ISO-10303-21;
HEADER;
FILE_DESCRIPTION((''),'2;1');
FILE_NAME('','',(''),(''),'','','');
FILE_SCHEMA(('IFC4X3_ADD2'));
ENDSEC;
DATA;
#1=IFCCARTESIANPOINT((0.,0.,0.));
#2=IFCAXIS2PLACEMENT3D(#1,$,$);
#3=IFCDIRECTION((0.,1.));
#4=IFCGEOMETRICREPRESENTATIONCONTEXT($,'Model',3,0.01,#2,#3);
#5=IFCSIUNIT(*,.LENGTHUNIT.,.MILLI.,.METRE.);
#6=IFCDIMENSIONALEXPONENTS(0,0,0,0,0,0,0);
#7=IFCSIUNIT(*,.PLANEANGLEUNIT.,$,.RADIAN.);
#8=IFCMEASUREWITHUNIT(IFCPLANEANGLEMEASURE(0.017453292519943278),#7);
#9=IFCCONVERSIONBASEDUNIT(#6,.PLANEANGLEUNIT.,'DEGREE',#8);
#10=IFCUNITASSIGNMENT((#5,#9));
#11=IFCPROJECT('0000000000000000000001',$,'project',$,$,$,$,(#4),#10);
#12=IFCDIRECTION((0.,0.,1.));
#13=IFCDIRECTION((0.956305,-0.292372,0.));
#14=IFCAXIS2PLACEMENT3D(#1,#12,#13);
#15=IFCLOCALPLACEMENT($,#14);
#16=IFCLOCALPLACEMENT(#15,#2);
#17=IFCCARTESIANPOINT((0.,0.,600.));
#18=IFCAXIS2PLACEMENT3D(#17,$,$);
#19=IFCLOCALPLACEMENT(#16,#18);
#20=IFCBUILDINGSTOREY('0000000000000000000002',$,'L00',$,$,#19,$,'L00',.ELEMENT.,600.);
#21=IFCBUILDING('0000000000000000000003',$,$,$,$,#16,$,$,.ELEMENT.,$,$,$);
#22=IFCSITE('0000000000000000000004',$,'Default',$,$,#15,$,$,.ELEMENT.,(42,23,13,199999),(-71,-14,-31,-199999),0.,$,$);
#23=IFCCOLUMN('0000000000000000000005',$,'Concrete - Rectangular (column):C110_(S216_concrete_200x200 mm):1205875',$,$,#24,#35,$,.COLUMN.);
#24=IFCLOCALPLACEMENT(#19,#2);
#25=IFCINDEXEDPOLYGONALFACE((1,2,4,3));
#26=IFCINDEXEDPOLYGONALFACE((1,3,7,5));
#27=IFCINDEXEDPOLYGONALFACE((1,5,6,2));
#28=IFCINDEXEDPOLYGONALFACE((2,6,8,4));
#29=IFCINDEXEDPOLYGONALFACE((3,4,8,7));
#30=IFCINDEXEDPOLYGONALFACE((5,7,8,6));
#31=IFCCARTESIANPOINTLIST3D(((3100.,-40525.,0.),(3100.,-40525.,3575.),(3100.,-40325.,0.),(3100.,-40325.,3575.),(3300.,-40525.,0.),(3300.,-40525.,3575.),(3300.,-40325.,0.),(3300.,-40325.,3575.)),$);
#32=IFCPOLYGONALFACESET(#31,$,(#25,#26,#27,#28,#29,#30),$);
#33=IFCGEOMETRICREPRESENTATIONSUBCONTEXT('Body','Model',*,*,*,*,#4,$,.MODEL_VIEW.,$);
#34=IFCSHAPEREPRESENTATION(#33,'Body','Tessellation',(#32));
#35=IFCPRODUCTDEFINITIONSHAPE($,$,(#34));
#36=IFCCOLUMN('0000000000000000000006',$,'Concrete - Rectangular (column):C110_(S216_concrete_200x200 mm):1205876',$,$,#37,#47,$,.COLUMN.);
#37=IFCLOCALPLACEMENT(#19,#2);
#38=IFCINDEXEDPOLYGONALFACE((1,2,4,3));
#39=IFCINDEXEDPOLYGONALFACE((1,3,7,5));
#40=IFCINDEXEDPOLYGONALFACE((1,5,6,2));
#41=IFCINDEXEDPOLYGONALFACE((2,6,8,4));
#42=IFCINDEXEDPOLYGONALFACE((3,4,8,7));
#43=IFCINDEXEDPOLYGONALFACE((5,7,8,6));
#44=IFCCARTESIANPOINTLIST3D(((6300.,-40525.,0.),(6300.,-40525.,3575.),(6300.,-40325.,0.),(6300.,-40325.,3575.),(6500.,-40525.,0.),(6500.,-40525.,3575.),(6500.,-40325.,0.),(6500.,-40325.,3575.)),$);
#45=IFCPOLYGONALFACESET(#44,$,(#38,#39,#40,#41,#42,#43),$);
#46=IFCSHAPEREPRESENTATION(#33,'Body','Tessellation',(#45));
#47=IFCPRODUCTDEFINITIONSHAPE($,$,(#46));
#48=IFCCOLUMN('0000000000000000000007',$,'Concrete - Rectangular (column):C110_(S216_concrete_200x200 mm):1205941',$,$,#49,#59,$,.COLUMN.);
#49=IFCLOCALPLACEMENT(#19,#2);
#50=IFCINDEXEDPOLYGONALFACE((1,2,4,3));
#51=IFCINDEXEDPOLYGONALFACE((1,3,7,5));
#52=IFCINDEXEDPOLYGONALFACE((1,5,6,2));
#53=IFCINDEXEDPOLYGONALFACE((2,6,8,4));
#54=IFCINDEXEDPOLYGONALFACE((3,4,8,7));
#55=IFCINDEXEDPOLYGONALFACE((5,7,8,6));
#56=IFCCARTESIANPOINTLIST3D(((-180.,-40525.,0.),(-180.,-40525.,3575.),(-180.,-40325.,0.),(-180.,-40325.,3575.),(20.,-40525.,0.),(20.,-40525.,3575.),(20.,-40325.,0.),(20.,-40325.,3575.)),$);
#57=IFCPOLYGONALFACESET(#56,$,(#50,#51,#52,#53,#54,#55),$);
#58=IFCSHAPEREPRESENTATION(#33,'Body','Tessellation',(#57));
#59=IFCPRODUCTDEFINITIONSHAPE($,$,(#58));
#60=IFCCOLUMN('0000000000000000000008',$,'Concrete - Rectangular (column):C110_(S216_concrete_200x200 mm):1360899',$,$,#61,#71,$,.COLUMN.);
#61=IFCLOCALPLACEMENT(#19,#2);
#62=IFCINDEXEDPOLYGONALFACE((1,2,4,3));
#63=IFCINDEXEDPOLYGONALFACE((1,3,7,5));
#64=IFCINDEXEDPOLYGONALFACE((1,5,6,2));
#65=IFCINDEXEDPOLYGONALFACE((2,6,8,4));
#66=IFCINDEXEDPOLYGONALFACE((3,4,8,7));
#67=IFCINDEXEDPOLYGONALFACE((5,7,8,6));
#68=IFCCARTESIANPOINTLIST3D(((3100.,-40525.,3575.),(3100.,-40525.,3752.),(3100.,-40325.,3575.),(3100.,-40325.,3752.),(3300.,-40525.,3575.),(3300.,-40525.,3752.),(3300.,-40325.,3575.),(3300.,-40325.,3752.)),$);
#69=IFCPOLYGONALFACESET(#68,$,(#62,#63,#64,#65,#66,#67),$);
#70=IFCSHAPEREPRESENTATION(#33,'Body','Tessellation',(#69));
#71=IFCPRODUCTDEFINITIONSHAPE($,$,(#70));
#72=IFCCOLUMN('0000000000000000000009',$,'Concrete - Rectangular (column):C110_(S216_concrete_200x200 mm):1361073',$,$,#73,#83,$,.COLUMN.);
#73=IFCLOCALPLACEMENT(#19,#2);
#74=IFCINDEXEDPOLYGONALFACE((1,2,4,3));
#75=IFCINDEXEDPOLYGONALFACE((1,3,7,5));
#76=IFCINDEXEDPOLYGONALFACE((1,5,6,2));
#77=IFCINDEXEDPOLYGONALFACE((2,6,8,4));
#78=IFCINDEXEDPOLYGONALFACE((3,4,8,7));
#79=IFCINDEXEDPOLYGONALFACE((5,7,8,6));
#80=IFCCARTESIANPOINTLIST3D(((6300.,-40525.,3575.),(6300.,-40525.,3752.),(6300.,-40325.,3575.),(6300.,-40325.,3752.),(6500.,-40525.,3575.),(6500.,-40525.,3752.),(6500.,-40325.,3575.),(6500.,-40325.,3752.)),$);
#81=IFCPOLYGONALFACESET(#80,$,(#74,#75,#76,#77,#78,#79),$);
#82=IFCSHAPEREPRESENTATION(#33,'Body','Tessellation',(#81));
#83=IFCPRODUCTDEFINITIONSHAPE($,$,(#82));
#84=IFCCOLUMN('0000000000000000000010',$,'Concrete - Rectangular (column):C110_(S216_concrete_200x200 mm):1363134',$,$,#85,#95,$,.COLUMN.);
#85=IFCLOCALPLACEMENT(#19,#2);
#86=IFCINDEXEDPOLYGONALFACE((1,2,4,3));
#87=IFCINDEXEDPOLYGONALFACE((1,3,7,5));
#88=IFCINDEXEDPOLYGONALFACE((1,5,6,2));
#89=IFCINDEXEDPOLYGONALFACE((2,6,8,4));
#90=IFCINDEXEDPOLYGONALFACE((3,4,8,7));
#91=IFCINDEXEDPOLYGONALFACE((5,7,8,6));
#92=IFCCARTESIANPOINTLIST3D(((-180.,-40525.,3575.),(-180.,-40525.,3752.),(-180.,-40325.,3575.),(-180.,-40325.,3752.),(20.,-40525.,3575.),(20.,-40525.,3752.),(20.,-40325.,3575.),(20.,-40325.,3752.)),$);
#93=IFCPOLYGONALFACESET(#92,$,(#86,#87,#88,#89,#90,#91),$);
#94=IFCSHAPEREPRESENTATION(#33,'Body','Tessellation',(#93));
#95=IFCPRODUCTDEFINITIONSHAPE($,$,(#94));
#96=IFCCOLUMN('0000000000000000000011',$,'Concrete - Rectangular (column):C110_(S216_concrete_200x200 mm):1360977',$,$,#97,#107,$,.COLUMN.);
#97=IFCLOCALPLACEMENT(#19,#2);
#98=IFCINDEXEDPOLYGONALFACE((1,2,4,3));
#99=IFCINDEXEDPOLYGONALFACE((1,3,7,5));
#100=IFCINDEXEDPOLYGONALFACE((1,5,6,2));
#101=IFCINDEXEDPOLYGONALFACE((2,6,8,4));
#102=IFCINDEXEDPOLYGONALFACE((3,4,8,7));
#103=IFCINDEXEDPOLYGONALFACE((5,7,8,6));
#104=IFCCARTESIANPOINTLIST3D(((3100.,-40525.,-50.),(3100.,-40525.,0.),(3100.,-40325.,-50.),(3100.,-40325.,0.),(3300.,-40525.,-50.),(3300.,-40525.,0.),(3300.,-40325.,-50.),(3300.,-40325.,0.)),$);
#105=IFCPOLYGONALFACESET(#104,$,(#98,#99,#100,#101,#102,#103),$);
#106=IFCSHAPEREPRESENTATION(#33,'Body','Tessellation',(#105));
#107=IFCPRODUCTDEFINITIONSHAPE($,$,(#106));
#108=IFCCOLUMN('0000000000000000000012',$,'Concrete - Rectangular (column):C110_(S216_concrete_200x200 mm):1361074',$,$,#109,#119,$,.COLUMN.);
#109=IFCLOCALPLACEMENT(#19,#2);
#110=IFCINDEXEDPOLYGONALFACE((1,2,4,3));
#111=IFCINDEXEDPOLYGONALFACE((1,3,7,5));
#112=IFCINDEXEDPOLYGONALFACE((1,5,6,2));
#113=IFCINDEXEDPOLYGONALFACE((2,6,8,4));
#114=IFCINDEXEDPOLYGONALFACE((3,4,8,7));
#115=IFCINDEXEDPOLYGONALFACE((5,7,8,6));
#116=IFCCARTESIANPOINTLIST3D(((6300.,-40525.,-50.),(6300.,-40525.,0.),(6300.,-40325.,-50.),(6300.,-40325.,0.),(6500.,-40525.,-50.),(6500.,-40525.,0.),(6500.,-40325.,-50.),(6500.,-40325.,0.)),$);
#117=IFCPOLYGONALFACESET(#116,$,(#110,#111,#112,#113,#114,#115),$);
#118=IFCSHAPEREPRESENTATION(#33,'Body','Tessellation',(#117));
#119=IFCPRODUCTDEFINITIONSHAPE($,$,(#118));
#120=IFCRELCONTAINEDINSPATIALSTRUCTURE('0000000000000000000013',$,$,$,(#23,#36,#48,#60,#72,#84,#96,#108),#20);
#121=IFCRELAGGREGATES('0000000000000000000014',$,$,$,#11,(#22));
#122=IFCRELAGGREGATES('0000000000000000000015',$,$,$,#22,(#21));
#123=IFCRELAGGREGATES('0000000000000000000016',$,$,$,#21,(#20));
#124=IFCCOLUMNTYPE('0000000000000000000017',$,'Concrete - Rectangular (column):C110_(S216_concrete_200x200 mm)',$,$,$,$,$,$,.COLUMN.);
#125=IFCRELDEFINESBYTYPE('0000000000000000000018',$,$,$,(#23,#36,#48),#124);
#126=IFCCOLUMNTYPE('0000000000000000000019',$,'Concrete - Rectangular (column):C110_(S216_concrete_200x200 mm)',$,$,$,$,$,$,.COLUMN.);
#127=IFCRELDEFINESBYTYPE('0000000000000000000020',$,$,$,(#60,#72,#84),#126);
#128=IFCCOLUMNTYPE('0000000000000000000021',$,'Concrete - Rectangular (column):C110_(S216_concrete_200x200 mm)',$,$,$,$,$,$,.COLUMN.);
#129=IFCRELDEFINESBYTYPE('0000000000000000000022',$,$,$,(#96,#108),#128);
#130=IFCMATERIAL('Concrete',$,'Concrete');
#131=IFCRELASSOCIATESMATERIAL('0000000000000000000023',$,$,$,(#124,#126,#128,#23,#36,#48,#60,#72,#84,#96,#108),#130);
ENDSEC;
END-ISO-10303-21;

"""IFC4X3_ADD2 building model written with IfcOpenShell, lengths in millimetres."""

from ifc_helpers import new_model, entity, si_unit, converted_unit, direction, frame, origin, origin_2d_with_axis, place, context, subcontext, project, spatial, rectangle, extrude, source, transform, mapped, material, material_profile, profile_set, profile_usage, type_object, type_shapes, element, save


model = new_model("IFC4X3_ADD2")

# Units and contexts
model_context = context("Model", 3, precision=0.01, world=origin(), true_north=direction((0.0, 1.0)))
body_context = subcontext(model_context, "Body", "Model", "MODEL_VIEW")
ifc_project = project(units=[si_unit("LENGTHUNIT", "METRE", prefix="MILLI"), converted_unit("PLANEANGLEUNIT", "DEGREE", entity("IfcPlaneAngleMeasure", 0.017453292519943278), si_unit("PLANEANGLEUNIT", "RADIAN"), dimensions=[0, 0, 0, 0, 0, 0, 0])], contexts=[model_context])

# Site, building, storey
site_placement = place(None, frame((0.0, 0.0, 0.0), z_axis=(0.0, 0.0, 1.0), x_axis=(0.956305, -0.292372, 0.0)))
site = spatial("IfcSite", under=ifc_project, at=site_placement, Name="Default", CompositionType="ELEMENT", RefLatitude=(42, 23, 13, 199999), RefLongitude=(-71, -14, -31, -199999), RefElevation=0.0)
building_placement = place(site_placement, origin())
building = spatial("IfcBuilding", under=site, at=building_placement, CompositionType="ELEMENT")
storey_placement = place(building_placement, frame((0.0, 0.0, 600.0)))
storey = spatial("IfcBuildingStorey", under=building, at=storey_placement, Name="L00", LongName="L00", CompositionType="ELEMENT", Elevation=600.0)

# Columns
ifc_material_1 = material(Name="Concrete", Category="Concrete")
ifc_material_profile_1 = material_profile(ifc_material_1, rectangle(XDim=200.0, YDim=200.0, at=origin_2d_with_axis()), Name="C110_(S216_concrete_200x200 mm)")
ifc_profile_set_1 = profile_set([ifc_material_profile_1], Name="C110_(S216_concrete_200x200 mm)")
ifc_profile_usage_1 = profile_usage(ifc_profile_set_1)
column_type_1 = type_object("IfcColumnType", Name="Concrete - Rectangular (column):C110_(S216_concrete_200x200 mm)", PredefinedType="COLUMN", material=ifc_profile_set_1)
shared_shape_1 = source(origin(), body_context, "Body", "SweptSolid", [
    extrude(rectangle(XDim=200.0, YDim=200.0, at=origin_2d_with_axis()), frame((0.0, 0.0, 600.0), z_axis=(0.0, 0.0, 1.0), x_axis=(-1.0, 0.0, 0.0)), (0.0, 0.0, 1.0), 3575.0),
])
type_shapes(column_type_1, [shared_shape_1])
for number, where, name in (
    (1, (3200.0, -40425.0, -600.0), "Concrete - Rectangular (column):C110_(S216_concrete_200x200 mm):1205875"),
    (2, (6400.0, -40425.0, -600.0), "Concrete - Rectangular (column):C110_(S216_concrete_200x200 mm):1205876"),
):
    element("IfcColumn", number, at=place(storey_placement, frame(where)), inside=storey, type_object=column_type_1, material=ifc_profile_usage_1, Name=name, PredefinedType="COLUMN", context=body_context, shape_type="MappedRepresentation", body=[
        mapped(shared_shape_1, transform((0.0, 0.0, 0.0), scale=1.0)),
    ])
column_placement = place(storey_placement, frame((-80.0, -40425.0, -600.0), z_axis=(0.0, 0.0, 1.0), x_axis=(0.0, -1.0, 0.0)))
element("IfcColumn", 3, at=column_placement, inside=storey, type_object=column_type_1, material=ifc_profile_usage_1, Name="Concrete - Rectangular (column):C110_(S216_concrete_200x200 mm):1205941", PredefinedType="COLUMN", context=body_context, shape_type="MappedRepresentation", body=[
    mapped(shared_shape_1, transform((0.0, 0.0, 0.0), scale=1.0)),
])
column_type_2 = type_object("IfcColumnType", Name="Concrete - Rectangular (column):C110_(S216_concrete_200x200 mm)", PredefinedType="COLUMN", material=ifc_profile_set_1)
shared_shape_2 = source(origin(), body_context, "Body", "SweptSolid", [
    extrude(rectangle(XDim=200.0, YDim=200.0, at=origin_2d_with_axis()), frame((0.0, 0.0, 4175.0), z_axis=(0.0, 0.0, 1.0), x_axis=(-1.0, 0.0, 0.0)), (0.0, 0.0, 1.0), 177.0),
])
type_shapes(column_type_2, [shared_shape_2])
for number, where, name in (
    (4, (3200.0, -40425.0, -600.0), "Concrete - Rectangular (column):C110_(S216_concrete_200x200 mm):1360899"),
    (5, (6400.0, -40425.0, -600.0), "Concrete - Rectangular (column):C110_(S216_concrete_200x200 mm):1361073"),
    (6, (-80.0, -40425.0, -600.0), "Concrete - Rectangular (column):C110_(S216_concrete_200x200 mm):1363134"),
):
    element("IfcColumn", number, at=place(storey_placement, frame(where)), inside=storey, type_object=column_type_2, material=ifc_profile_usage_1, Name=name, PredefinedType="COLUMN", context=body_context, shape_type="MappedRepresentation", body=[
        mapped(shared_shape_2, transform((0.0, 0.0, 0.0), scale=1.0)),
    ])
column_type_3 = type_object("IfcColumnType", Name="Concrete - Rectangular (column):C110_(S216_concrete_200x200 mm)", PredefinedType="COLUMN", material=ifc_profile_set_1)
shared_shape_3 = source(origin(), body_context, "Body", "SweptSolid", [
    extrude(rectangle(XDim=200.0, YDim=200.0, at=origin_2d_with_axis()), frame((0.0, 0.0, 550.0), z_axis=(0.0, 0.0, 1.0), x_axis=(-1.0, 0.0, 0.0)), (0.0, 0.0, 1.0), 50.0),
])
type_shapes(column_type_3, [shared_shape_3])
for number, where, name in (
    (7, (3200.0, -40425.0, -600.0), "Concrete - Rectangular (column):C110_(S216_concrete_200x200 mm):1360977"),
    (8, (6400.0, -40425.0, -600.0), "Concrete - Rectangular (column):C110_(S216_concrete_200x200 mm):1361074"),
):
    element("IfcColumn", number, at=place(storey_placement, frame(where)), inside=storey, type_object=column_type_3, material=ifc_profile_usage_1, Name=name, PredefinedType="COLUMN", context=body_context, shape_type="MappedRepresentation", body=[
        mapped(shared_shape_3, transform((0.0, 0.0, 0.0), scale=1.0)),
    ])

save(model, "model.ifc")
